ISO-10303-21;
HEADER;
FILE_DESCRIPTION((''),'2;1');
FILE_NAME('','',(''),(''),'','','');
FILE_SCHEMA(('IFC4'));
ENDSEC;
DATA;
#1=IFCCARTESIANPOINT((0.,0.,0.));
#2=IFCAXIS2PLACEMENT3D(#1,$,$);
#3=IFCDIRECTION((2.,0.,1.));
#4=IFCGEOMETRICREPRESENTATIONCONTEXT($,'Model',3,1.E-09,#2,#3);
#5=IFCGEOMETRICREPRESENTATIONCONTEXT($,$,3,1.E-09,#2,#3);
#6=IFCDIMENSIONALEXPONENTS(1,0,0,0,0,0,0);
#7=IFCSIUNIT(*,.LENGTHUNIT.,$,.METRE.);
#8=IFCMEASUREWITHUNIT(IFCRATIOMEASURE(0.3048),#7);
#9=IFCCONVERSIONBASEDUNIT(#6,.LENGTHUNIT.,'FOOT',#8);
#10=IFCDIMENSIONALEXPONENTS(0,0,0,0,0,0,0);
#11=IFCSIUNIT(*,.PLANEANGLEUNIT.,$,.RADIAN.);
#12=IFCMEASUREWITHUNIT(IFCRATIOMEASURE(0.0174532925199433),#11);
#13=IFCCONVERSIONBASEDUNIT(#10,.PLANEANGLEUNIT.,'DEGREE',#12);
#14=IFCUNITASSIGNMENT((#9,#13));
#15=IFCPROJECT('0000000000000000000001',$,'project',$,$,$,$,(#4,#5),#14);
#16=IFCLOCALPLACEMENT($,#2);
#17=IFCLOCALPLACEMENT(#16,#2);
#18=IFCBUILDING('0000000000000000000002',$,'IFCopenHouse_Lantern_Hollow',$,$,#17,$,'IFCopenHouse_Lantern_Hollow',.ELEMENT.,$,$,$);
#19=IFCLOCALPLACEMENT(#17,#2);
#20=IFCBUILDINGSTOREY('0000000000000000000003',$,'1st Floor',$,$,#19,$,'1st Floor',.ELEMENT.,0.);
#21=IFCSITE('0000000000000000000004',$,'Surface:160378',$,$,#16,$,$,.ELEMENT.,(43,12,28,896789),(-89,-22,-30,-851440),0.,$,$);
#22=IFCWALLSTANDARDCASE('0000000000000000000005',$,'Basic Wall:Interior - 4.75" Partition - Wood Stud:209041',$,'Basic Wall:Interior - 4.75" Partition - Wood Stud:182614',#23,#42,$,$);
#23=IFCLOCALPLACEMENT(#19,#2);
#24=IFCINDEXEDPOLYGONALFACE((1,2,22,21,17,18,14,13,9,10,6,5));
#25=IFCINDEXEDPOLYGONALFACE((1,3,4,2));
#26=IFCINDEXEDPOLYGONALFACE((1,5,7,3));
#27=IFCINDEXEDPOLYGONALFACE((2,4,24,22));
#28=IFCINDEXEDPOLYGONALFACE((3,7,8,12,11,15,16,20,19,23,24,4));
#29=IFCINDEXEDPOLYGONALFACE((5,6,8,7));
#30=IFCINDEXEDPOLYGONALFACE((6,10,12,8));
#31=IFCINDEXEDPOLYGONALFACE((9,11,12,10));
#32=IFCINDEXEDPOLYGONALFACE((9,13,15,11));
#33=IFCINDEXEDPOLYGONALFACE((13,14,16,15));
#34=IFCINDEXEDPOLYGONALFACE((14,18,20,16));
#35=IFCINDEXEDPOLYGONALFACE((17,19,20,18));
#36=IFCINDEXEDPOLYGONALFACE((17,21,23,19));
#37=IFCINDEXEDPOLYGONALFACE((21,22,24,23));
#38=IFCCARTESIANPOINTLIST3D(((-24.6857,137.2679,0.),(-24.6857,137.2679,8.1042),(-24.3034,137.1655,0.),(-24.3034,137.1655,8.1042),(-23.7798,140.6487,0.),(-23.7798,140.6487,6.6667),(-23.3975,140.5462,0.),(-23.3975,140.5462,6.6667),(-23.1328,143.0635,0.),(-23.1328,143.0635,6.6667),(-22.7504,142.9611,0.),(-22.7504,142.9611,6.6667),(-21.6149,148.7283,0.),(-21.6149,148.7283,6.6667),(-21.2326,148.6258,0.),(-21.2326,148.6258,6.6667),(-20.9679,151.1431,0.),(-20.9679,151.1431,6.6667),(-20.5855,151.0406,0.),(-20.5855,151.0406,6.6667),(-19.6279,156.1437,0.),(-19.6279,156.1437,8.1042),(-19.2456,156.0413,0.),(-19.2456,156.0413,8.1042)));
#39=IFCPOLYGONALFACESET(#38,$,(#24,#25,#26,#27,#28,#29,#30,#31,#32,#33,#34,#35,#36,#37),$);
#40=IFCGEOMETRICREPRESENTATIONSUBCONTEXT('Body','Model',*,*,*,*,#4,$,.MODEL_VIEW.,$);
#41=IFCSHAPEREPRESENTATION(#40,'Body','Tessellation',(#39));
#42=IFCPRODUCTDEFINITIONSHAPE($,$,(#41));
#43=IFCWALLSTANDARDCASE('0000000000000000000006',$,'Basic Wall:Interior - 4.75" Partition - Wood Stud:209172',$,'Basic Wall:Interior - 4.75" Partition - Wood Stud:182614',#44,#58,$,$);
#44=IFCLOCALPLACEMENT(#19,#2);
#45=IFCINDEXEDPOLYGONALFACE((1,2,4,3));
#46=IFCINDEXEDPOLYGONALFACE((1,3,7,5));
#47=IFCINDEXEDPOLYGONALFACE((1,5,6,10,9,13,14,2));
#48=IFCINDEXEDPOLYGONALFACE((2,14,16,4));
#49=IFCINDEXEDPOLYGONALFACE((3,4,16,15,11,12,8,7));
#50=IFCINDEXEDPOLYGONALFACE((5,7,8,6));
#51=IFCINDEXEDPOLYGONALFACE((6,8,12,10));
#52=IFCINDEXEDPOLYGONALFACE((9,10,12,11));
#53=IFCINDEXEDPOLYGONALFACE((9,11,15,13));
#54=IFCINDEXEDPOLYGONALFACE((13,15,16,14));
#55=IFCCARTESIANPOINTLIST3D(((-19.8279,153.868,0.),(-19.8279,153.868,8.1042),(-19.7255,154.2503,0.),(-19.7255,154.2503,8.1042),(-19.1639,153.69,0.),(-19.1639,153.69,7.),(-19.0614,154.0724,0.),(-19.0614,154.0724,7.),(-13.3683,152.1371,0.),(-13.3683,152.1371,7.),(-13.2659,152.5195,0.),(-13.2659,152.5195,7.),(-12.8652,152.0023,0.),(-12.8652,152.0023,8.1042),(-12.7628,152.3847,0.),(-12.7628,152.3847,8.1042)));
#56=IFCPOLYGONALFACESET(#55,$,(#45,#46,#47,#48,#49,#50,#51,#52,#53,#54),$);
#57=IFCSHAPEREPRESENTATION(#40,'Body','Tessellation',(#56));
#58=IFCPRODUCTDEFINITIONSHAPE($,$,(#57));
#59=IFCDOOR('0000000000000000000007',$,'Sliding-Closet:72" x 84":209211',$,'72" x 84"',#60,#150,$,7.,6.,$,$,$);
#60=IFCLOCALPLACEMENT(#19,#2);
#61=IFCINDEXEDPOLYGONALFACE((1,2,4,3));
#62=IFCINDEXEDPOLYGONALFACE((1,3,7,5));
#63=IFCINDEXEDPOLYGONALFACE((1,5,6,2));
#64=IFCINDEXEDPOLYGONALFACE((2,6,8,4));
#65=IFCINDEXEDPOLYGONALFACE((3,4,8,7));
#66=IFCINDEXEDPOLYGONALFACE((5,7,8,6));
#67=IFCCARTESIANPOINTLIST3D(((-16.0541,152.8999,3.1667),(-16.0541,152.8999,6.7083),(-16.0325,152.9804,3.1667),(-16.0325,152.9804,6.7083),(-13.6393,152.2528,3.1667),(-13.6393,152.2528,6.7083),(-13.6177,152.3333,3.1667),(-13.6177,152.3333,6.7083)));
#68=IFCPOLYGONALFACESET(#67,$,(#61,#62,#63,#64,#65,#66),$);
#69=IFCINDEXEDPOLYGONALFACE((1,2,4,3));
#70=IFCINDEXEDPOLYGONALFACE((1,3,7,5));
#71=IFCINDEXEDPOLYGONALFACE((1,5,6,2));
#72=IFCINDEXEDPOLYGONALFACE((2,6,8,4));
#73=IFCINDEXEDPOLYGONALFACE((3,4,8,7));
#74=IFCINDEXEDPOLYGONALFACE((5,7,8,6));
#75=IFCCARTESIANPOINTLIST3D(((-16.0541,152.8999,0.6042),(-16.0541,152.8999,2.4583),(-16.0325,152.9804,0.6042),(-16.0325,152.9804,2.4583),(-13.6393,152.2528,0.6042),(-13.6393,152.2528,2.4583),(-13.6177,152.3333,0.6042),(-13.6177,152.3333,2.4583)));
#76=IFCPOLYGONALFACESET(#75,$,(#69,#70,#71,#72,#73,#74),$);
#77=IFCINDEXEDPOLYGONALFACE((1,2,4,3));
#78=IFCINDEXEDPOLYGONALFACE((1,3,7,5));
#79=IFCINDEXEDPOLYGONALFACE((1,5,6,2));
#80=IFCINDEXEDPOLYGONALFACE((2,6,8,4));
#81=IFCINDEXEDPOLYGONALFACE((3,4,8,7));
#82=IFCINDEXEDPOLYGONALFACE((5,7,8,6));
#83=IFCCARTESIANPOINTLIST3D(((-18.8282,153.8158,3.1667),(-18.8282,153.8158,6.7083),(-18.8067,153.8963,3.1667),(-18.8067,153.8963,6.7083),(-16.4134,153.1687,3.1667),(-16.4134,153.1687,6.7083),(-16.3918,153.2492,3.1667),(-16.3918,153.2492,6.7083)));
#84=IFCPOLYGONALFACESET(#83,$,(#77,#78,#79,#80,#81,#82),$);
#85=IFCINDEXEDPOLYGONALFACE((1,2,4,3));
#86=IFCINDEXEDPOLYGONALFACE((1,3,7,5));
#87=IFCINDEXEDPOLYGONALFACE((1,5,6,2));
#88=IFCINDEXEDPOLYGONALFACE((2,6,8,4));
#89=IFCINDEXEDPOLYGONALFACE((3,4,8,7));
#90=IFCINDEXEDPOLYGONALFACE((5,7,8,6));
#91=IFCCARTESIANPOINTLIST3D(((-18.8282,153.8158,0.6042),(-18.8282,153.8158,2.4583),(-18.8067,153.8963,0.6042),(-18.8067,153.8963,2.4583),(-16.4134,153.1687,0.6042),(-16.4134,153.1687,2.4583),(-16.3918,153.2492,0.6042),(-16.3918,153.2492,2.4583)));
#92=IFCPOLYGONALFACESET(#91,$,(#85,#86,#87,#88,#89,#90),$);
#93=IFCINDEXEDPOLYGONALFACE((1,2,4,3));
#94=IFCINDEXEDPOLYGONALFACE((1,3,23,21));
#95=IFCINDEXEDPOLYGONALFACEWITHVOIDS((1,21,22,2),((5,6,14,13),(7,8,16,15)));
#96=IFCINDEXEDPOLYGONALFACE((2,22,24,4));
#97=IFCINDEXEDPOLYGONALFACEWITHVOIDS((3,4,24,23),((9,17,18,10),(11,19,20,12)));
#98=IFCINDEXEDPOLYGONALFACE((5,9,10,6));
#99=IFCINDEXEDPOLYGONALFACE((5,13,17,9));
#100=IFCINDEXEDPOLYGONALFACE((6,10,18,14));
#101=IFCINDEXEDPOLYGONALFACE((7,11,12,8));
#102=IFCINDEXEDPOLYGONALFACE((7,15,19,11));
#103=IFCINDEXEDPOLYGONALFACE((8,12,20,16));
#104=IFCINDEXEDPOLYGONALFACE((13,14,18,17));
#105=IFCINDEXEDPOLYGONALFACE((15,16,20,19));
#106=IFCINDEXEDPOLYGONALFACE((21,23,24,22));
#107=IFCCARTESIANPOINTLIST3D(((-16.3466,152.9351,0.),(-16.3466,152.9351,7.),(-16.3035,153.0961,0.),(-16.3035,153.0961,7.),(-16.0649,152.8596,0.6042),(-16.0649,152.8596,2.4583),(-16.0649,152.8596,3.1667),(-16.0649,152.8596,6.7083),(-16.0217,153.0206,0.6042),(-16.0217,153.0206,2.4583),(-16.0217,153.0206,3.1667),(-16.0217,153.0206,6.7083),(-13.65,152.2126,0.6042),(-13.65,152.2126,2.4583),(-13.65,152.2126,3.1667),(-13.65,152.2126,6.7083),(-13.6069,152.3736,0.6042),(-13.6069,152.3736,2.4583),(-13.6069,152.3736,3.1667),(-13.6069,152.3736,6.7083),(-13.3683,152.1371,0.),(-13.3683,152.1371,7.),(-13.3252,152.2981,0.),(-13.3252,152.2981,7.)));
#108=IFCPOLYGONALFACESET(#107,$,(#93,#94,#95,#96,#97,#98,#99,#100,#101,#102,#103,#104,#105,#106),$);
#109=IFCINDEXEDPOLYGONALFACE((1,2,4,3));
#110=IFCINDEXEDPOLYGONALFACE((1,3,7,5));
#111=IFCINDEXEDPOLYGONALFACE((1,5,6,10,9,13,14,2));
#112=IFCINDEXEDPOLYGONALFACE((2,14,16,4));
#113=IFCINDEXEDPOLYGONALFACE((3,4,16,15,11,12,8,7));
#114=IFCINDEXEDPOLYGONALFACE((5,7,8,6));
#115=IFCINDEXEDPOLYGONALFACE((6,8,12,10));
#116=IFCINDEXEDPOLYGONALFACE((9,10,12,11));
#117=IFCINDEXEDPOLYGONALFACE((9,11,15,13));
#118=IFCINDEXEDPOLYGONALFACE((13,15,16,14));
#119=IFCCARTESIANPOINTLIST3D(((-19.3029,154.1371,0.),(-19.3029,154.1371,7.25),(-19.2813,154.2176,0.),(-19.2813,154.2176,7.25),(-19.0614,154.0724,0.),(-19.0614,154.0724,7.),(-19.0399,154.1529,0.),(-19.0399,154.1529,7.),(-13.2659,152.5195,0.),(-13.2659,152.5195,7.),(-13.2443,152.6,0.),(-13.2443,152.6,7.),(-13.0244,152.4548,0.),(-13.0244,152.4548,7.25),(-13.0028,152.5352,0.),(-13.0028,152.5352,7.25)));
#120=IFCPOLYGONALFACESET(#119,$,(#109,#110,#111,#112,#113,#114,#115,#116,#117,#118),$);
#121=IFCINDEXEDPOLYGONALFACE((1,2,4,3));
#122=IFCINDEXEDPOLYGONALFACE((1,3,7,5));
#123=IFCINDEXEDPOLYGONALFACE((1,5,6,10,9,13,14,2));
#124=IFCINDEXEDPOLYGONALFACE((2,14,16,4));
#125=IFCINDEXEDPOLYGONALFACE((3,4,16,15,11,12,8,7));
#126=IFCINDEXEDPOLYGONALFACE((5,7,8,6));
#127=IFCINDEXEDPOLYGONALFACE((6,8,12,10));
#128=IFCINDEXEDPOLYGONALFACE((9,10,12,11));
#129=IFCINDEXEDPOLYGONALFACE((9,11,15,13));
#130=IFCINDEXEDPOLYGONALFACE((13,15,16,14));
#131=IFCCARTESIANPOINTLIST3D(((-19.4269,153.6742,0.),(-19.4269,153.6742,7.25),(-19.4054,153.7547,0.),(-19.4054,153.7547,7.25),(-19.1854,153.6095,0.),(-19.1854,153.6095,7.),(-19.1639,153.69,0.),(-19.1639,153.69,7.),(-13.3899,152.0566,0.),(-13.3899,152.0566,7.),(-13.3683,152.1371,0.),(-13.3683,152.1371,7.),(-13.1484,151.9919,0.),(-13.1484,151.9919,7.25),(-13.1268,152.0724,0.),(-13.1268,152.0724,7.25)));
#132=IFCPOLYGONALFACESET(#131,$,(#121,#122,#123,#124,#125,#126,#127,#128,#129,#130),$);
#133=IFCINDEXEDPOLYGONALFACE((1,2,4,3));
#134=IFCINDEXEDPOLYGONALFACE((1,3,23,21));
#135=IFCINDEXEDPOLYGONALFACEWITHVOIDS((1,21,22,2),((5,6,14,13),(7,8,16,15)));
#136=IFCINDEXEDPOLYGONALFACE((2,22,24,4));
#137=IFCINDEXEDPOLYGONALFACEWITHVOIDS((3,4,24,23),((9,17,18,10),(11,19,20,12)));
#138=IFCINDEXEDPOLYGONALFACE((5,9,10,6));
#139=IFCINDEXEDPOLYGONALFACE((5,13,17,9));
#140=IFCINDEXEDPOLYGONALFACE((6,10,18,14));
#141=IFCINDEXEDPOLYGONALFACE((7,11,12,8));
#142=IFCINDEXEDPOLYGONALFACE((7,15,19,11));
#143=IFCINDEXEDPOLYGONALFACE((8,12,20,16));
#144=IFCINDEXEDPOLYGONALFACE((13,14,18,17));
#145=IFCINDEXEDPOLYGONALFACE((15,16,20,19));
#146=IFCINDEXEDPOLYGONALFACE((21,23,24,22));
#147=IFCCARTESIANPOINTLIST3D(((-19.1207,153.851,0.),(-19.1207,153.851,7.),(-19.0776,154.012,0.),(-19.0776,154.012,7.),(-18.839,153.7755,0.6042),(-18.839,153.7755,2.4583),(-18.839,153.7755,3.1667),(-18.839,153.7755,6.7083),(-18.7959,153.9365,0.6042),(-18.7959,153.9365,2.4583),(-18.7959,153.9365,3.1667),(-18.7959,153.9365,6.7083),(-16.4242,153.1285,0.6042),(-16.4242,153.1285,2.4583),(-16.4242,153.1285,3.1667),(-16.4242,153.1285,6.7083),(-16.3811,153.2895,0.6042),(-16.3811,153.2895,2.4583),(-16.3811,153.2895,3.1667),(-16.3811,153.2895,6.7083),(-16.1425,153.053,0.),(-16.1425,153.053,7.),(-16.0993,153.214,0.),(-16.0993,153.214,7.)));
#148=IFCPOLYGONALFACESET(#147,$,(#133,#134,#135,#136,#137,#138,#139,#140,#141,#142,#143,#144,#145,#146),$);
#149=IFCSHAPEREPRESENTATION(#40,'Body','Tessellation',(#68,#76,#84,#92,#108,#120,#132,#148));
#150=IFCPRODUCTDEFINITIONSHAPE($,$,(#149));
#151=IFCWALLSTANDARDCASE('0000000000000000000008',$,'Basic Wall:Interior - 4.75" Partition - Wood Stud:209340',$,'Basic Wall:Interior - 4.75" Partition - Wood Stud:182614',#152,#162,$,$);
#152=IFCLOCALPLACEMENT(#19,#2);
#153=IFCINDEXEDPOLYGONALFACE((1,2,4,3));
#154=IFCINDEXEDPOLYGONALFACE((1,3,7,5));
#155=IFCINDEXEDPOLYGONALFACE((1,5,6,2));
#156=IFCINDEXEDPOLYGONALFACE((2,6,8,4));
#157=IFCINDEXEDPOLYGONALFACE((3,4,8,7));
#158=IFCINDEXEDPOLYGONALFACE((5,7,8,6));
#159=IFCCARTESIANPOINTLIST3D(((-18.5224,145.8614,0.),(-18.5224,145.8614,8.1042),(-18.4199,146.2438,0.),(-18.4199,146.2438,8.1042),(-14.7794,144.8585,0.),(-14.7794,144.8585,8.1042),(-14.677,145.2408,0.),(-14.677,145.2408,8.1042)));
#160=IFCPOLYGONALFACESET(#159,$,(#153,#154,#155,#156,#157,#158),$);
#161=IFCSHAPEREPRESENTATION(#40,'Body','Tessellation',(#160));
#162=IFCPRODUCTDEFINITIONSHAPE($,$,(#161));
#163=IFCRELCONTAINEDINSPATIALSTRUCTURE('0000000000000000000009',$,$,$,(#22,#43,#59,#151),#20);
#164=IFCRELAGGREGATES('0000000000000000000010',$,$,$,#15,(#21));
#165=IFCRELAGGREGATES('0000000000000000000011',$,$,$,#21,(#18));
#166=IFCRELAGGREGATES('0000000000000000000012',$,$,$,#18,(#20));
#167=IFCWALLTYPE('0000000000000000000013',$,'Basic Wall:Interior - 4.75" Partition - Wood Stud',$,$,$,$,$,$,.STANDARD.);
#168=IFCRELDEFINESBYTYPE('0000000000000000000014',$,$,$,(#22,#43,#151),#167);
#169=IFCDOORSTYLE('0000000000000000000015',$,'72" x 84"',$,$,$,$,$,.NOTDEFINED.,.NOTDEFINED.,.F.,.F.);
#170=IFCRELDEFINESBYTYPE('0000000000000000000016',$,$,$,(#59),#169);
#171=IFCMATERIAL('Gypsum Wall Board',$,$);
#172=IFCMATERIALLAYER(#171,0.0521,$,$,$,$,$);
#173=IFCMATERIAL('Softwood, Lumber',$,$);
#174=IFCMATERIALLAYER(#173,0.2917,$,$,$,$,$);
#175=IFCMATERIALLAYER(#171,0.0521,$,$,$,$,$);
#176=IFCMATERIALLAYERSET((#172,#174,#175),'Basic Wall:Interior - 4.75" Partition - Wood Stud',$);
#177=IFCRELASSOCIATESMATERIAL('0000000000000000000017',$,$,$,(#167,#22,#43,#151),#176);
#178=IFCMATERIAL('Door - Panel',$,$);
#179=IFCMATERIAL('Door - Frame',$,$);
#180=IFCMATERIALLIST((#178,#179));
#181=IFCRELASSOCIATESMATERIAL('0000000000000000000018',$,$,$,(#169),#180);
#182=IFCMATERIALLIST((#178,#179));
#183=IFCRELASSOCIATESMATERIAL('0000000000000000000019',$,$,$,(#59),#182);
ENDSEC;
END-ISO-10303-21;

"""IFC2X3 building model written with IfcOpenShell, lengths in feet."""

from ifc_helpers import new_model, entity, si_unit, converted_unit, direction, frame, frame_2d, origin, origin_2d_with_axis, place, context, subcontext, project, spatial, polyline, rectangle, outline, extrude, source, transform, mapped, material, material_list, layer, layer_set, layer_usage, type_object, type_shapes, element, fill, save


model = new_model("IFC2X3")

# Units and contexts
model_context = context("Model", 3, precision=1e-09, world=origin(), true_north=direction((2.0, 0.0, 1.0)))
context_of_model = context(None, 3, precision=1e-09, world=origin(), true_north=direction((2.0, 0.0, 1.0)))
body_context = subcontext(model_context, "Body", "Model", "MODEL_VIEW")
ifc_project = project(units=[converted_unit("LENGTHUNIT", "FOOT", entity("IfcRatioMeasure", 0.3048), si_unit("LENGTHUNIT", "METRE"), dimensions=[1, 0, 0, 0, 0, 0, 0]), converted_unit("PLANEANGLEUNIT", "DEGREE", entity("IfcRatioMeasure", 0.0174532925199433), si_unit("PLANEANGLEUNIT", "RADIAN"), dimensions=[0, 0, 0, 0, 0, 0, 0])], contexts=[model_context, context_of_model])

# Site, building, storey
site_placement = place(None, origin())
site = spatial("IfcSite", under=ifc_project, at=site_placement, Name="Surface:160378", CompositionType="ELEMENT", RefLatitude=(43, 12, 28, 896789), RefLongitude=(-89, -22, -30, -851440), RefElevation=0.0)
building_placement = place(site_placement, origin())
building = spatial("IfcBuilding", under=site, at=building_placement, Name="IFCopenHouse_Lantern_Hollow", LongName="IFCopenHouse_Lantern_Hollow", CompositionType="ELEMENT")
storey_placement = place(building_placement, origin())
storey = spatial("IfcBuildingStorey", under=building, at=storey_placement, Name="1st Floor", LongName="1st Floor", CompositionType="ELEMENT", Elevation=0.0)

# Wall, openings
ifc_material_1 = material(Name="Gypsum Wall Board")
ifc_layer_1 = layer(ifc_material_1, 0.0521)
ifc_material_2 = material(Name="Softwood, Lumber")
ifc_layer_2 = layer(ifc_material_2, 0.2917)
ifc_layer_3 = layer(ifc_material_1, 0.0521)
ifc_layer_set_1 = layer_set([ifc_layer_1, ifc_layer_2, ifc_layer_3], Name="Basic Wall:Interior - 4.75\" Partition - Wood Stud")
ifc_layer_usage_1 = layer_usage(ifc_layer_set_1, "AXIS2", "NEGATIVE", 0.1979)
wall_type_1 = type_object("IfcWallType", Name="Basic Wall:Interior - 4.75\" Partition - Wood Stud", PredefinedType="STANDARD", material=ifc_layer_set_1)
wall_1_placement = place(storey_placement, frame((-19.4368, 156.0925, 0.0), z_axis=(0.0, 0.0, 1.0), x_axis=(-0.258819, -0.965926, 0.0)))
wall_1 = element("IfcWallStandardCase", 1, at=wall_1_placement, inside=storey, type_object=wall_type_1, material=ifc_layer_usage_1, Name="Basic Wall:Interior - 4.75\" Partition - Wood Stud:209041", ObjectType="Basic Wall:Interior - 4.75\" Partition - Wood Stud:182614", context=body_context, shape_type="SweptSolid", body=[
    extrude(rectangle(XDim=19.5417, YDim=0.3958, at=frame_2d((9.7708, 0.0), x_axis=(-1.0, 0.0))), origin(), (0.0, 0.0, 1.0), 8.1042),
])
opening_1_placement = place(wall_1_placement, origin())
element("IfcOpeningElement", 2, at=opening_1_placement, cuts=wall_1, ObjectType="Opening", context=body_context, shape_type="SweptSolid", body=[
    extrude(rectangle(XDim=6.6667, YDim=2.5, at=origin_2d_with_axis()), frame((6.4271, -0.1979, 3.3333), z_axis=(0.0, 1.0, 0.0), x_axis=(0.0, 0.0, -1.0)), (0.0, 0.0, 1.0), 0.3958),
])
opening_2_placement = place(wall_1_placement, origin())
element("IfcOpeningElement", 3, at=opening_2_placement, cuts=wall_1, ObjectType="Opening", context=body_context, shape_type="SweptSolid", body=[
    extrude(rectangle(XDim=6.6667, YDim=2.5, at=origin_2d_with_axis()), frame((14.7917, -0.1979, 3.3333), z_axis=(0.0, 1.0, 0.0), x_axis=(0.0, 0.0, -1.0)), (0.0, 0.0, 1.0), 0.3958),
])

# Wall, opening, door
ifc_layer_usage_2 = layer_usage(ifc_layer_set_1, "AXIS2", "NEGATIVE", 0.1979)
wall_2_placement = place(storey_placement, frame((-19.7767, 154.0591, 0.0), z_axis=(0.0, 0.0, 1.0), x_axis=(0.965926, -0.258819, 0.0)))
wall_2 = element("IfcWallStandardCase", 4, at=wall_2_placement, inside=storey, type_object=wall_type_1, material=ifc_layer_usage_2, Name="Basic Wall:Interior - 4.75\" Partition - Wood Stud:209172", ObjectType="Basic Wall:Interior - 4.75\" Partition - Wood Stud:182614", context=body_context, shape_type="SweptSolid", body=[
    extrude(rectangle(XDim=7.2083, YDim=0.3958, at=frame_2d((3.6042, 0.0), x_axis=(-1.0, 0.0))), origin(), (0.0, 0.0, 1.0), 8.1042),
])
opening_3_placement = place(wall_2_placement, frame((6.6875, 0.1979, 0.0)))
opening_3 = element("IfcOpeningElement", 5, at=opening_3_placement, cuts=wall_2, ObjectType="Opening", context=body_context, shape_type="SweptSolid", body=[
    extrude(rectangle(XDim=7.0, YDim=6.0, at=frame_2d((3.5, 3.0), x_axis=(-1.0, 0.0))), frame((0.0, 0.0, 0.0), z_axis=(0.0, -1.0, 0.0), x_axis=(0.0, 0.0, 1.0)), (0.0, 0.0, 1.0), 0.3958),
])
ifc_material_3 = material(Name="Door - Panel")
ifc_material_4 = material(Name="Door - Frame")
ifc_material_list_1 = material_list([ifc_material_3, ifc_material_4])
ifc_material_list_2 = material_list([ifc_material_3, ifc_material_4])
door_style_1 = type_object("IfcDoorStyle", Name="72\" x 84\"", ConstructionType="NOTDEFINED", OperationType="NOTDEFINED", ParameterTakesPrecedence=False, Sizeable=False, material=ifc_material_list_2)
shared_shape_1 = source(origin(), body_context, "Body", "SweptSolid", [
    extrude(rectangle(XDim=0.0833, YDim=2.5, at=origin_2d_with_axis()), frame((1.5417, 0.3125, 3.1667), z_axis=(0.0, 0.0, 1.0), x_axis=(0.0, 1.0, 0.0)), (0.0, 0.0, 1.0), 3.5417),
    extrude(rectangle(XDim=0.0833, YDim=2.5, at=origin_2d_with_axis()), frame((1.5417, 0.3125, 0.6042), z_axis=(0.0, 0.0, 1.0), x_axis=(0.0, 1.0, 0.0)), (0.0, 0.0, 1.0), 1.8542),
    extrude(rectangle(XDim=0.0833, YDim=2.5, at=origin_2d_with_axis()), frame((4.4583, 0.1458, 3.1667), z_axis=(0.0, 0.0, 1.0), x_axis=(0.0, -1.0, 0.0)), (0.0, 0.0, 1.0), 3.5417),
    extrude(rectangle(XDim=0.0833, YDim=2.5, at=origin_2d_with_axis()), frame((4.4583, 0.1458, 0.6042), z_axis=(0.0, 0.0, 1.0), x_axis=(0.0, -1.0, 0.0)), (0.0, 0.0, 1.0), 1.8542),
    extrude(outline(polyline([(-3.5, -1.5417), (3.5, -1.5417), (3.5, 1.5417), (-3.5, 1.5417), (-3.5, -1.5417)]), holes=[polyline([(2.8958, 1.25), (2.8958, -1.25), (1.0417, -1.25), (1.0417, 1.25), (2.8958, 1.25)]), polyline([(0.3333, 1.25), (0.3333, -1.25), (-3.2083, -1.25), (-3.2083, 1.25), (0.3333, 1.25)])]), frame((1.5417, 0.2292, 3.5), z_axis=(0.0, 1.0, 0.0), x_axis=(0.0, 0.0, -1.0)), (0.0, 0.0, 1.0), 0.1667),
    extrude(outline(polyline([(-3.5625, -3.25), (3.6875, -3.25), (3.6875, 3.25), (-3.5625, 3.25), (-3.5625, 3.0), (3.4375, 3.0), (3.4375, -3.0), (-3.5625, -3.0), (-3.5625, -3.25)])), frame((3.0, -0.0833, 3.5625), z_axis=(0.0, 1.0, 0.0), x_axis=(0.0, 0.0, 1.0)), (0.0, 0.0, 1.0), 0.0833),
    extrude(outline(polyline([(-3.25, -3.5625), (-3.0, -3.5625), (-3.0, 3.4375), (3.0, 3.4375), (3.0, -3.5625), (3.25, -3.5625), (3.25, 3.6875), (-3.25, 3.6875), (-3.25, -3.5625)])), frame((3.0, 0.3958, 3.5625), z_axis=(0.0, 1.0, 0.0), x_axis=(-1.0, 0.0, 0.0)), (0.0, 0.0, 1.0), 0.0833),
    extrude(outline(polyline([(-1.5417, -3.5), (1.5417, -3.5), (1.5417, 3.5), (-1.5417, 3.5), (-1.5417, -3.5)]), holes=[polyline([(1.25, 0.3333), (1.25, -3.2083), (-1.25, -3.2083), (-1.25, 0.3333), (1.25, 0.3333)]), polyline([(1.25, 2.8958), (1.25, 1.0417), (-1.25, 1.0417), (-1.25, 2.8958), (1.25, 2.8958)])]), frame((4.4583, 0.0625, 3.5), z_axis=(0.0, 1.0, 0.0), x_axis=(1.0, 0.0, 0.0)), (0.0, 0.0, 1.0), 0.1667),
])
type_shapes(door_style_1, [shared_shape_1])
door_1_placement = place(storey_placement, frame((-13.2659, 152.5195, 0.0), z_axis=(0.0, 0.0, 1.0), x_axis=(-0.965926, 0.258819, 0.0)))
door_1 = element("IfcDoor", 6, at=door_1_placement, inside=storey, type_object=door_style_1, material=ifc_material_list_1, Name="Sliding-Closet:72\" x 84\":209211", ObjectType="72\" x 84\"", OverallHeight=7.0, OverallWidth=6.0, context=body_context, shape_type="MappedRepresentation", body=[
    mapped(shared_shape_1, transform((0.0, 0.0, 0.0), scale=1.0)),
])
fill(opening_3, door_1)

# Wall
ifc_layer_usage_3 = layer_usage(ifc_layer_set_1, "AXIS2", "NEGATIVE", 0.1979)
wall_3_placement = place(storey_placement, frame((-18.4712, 146.0526, 0.0), z_axis=(0.0, 0.0, 1.0), x_axis=(0.965926, -0.258819, 0.0)))
element("IfcWallStandardCase", 7, at=wall_3_placement, inside=storey, type_object=wall_type_1, material=ifc_layer_usage_3, Name="Basic Wall:Interior - 4.75\" Partition - Wood Stud:209340", ObjectType="Basic Wall:Interior - 4.75\" Partition - Wood Stud:182614", context=body_context, shape_type="SweptSolid", body=[
    extrude(rectangle(XDim=3.875, YDim=0.3958, at=frame_2d((1.9375, 0.0), x_axis=(-1.0, 0.0))), origin(), (0.0, 0.0, 1.0), 8.1042),
])

save(model, "model.ifc")
